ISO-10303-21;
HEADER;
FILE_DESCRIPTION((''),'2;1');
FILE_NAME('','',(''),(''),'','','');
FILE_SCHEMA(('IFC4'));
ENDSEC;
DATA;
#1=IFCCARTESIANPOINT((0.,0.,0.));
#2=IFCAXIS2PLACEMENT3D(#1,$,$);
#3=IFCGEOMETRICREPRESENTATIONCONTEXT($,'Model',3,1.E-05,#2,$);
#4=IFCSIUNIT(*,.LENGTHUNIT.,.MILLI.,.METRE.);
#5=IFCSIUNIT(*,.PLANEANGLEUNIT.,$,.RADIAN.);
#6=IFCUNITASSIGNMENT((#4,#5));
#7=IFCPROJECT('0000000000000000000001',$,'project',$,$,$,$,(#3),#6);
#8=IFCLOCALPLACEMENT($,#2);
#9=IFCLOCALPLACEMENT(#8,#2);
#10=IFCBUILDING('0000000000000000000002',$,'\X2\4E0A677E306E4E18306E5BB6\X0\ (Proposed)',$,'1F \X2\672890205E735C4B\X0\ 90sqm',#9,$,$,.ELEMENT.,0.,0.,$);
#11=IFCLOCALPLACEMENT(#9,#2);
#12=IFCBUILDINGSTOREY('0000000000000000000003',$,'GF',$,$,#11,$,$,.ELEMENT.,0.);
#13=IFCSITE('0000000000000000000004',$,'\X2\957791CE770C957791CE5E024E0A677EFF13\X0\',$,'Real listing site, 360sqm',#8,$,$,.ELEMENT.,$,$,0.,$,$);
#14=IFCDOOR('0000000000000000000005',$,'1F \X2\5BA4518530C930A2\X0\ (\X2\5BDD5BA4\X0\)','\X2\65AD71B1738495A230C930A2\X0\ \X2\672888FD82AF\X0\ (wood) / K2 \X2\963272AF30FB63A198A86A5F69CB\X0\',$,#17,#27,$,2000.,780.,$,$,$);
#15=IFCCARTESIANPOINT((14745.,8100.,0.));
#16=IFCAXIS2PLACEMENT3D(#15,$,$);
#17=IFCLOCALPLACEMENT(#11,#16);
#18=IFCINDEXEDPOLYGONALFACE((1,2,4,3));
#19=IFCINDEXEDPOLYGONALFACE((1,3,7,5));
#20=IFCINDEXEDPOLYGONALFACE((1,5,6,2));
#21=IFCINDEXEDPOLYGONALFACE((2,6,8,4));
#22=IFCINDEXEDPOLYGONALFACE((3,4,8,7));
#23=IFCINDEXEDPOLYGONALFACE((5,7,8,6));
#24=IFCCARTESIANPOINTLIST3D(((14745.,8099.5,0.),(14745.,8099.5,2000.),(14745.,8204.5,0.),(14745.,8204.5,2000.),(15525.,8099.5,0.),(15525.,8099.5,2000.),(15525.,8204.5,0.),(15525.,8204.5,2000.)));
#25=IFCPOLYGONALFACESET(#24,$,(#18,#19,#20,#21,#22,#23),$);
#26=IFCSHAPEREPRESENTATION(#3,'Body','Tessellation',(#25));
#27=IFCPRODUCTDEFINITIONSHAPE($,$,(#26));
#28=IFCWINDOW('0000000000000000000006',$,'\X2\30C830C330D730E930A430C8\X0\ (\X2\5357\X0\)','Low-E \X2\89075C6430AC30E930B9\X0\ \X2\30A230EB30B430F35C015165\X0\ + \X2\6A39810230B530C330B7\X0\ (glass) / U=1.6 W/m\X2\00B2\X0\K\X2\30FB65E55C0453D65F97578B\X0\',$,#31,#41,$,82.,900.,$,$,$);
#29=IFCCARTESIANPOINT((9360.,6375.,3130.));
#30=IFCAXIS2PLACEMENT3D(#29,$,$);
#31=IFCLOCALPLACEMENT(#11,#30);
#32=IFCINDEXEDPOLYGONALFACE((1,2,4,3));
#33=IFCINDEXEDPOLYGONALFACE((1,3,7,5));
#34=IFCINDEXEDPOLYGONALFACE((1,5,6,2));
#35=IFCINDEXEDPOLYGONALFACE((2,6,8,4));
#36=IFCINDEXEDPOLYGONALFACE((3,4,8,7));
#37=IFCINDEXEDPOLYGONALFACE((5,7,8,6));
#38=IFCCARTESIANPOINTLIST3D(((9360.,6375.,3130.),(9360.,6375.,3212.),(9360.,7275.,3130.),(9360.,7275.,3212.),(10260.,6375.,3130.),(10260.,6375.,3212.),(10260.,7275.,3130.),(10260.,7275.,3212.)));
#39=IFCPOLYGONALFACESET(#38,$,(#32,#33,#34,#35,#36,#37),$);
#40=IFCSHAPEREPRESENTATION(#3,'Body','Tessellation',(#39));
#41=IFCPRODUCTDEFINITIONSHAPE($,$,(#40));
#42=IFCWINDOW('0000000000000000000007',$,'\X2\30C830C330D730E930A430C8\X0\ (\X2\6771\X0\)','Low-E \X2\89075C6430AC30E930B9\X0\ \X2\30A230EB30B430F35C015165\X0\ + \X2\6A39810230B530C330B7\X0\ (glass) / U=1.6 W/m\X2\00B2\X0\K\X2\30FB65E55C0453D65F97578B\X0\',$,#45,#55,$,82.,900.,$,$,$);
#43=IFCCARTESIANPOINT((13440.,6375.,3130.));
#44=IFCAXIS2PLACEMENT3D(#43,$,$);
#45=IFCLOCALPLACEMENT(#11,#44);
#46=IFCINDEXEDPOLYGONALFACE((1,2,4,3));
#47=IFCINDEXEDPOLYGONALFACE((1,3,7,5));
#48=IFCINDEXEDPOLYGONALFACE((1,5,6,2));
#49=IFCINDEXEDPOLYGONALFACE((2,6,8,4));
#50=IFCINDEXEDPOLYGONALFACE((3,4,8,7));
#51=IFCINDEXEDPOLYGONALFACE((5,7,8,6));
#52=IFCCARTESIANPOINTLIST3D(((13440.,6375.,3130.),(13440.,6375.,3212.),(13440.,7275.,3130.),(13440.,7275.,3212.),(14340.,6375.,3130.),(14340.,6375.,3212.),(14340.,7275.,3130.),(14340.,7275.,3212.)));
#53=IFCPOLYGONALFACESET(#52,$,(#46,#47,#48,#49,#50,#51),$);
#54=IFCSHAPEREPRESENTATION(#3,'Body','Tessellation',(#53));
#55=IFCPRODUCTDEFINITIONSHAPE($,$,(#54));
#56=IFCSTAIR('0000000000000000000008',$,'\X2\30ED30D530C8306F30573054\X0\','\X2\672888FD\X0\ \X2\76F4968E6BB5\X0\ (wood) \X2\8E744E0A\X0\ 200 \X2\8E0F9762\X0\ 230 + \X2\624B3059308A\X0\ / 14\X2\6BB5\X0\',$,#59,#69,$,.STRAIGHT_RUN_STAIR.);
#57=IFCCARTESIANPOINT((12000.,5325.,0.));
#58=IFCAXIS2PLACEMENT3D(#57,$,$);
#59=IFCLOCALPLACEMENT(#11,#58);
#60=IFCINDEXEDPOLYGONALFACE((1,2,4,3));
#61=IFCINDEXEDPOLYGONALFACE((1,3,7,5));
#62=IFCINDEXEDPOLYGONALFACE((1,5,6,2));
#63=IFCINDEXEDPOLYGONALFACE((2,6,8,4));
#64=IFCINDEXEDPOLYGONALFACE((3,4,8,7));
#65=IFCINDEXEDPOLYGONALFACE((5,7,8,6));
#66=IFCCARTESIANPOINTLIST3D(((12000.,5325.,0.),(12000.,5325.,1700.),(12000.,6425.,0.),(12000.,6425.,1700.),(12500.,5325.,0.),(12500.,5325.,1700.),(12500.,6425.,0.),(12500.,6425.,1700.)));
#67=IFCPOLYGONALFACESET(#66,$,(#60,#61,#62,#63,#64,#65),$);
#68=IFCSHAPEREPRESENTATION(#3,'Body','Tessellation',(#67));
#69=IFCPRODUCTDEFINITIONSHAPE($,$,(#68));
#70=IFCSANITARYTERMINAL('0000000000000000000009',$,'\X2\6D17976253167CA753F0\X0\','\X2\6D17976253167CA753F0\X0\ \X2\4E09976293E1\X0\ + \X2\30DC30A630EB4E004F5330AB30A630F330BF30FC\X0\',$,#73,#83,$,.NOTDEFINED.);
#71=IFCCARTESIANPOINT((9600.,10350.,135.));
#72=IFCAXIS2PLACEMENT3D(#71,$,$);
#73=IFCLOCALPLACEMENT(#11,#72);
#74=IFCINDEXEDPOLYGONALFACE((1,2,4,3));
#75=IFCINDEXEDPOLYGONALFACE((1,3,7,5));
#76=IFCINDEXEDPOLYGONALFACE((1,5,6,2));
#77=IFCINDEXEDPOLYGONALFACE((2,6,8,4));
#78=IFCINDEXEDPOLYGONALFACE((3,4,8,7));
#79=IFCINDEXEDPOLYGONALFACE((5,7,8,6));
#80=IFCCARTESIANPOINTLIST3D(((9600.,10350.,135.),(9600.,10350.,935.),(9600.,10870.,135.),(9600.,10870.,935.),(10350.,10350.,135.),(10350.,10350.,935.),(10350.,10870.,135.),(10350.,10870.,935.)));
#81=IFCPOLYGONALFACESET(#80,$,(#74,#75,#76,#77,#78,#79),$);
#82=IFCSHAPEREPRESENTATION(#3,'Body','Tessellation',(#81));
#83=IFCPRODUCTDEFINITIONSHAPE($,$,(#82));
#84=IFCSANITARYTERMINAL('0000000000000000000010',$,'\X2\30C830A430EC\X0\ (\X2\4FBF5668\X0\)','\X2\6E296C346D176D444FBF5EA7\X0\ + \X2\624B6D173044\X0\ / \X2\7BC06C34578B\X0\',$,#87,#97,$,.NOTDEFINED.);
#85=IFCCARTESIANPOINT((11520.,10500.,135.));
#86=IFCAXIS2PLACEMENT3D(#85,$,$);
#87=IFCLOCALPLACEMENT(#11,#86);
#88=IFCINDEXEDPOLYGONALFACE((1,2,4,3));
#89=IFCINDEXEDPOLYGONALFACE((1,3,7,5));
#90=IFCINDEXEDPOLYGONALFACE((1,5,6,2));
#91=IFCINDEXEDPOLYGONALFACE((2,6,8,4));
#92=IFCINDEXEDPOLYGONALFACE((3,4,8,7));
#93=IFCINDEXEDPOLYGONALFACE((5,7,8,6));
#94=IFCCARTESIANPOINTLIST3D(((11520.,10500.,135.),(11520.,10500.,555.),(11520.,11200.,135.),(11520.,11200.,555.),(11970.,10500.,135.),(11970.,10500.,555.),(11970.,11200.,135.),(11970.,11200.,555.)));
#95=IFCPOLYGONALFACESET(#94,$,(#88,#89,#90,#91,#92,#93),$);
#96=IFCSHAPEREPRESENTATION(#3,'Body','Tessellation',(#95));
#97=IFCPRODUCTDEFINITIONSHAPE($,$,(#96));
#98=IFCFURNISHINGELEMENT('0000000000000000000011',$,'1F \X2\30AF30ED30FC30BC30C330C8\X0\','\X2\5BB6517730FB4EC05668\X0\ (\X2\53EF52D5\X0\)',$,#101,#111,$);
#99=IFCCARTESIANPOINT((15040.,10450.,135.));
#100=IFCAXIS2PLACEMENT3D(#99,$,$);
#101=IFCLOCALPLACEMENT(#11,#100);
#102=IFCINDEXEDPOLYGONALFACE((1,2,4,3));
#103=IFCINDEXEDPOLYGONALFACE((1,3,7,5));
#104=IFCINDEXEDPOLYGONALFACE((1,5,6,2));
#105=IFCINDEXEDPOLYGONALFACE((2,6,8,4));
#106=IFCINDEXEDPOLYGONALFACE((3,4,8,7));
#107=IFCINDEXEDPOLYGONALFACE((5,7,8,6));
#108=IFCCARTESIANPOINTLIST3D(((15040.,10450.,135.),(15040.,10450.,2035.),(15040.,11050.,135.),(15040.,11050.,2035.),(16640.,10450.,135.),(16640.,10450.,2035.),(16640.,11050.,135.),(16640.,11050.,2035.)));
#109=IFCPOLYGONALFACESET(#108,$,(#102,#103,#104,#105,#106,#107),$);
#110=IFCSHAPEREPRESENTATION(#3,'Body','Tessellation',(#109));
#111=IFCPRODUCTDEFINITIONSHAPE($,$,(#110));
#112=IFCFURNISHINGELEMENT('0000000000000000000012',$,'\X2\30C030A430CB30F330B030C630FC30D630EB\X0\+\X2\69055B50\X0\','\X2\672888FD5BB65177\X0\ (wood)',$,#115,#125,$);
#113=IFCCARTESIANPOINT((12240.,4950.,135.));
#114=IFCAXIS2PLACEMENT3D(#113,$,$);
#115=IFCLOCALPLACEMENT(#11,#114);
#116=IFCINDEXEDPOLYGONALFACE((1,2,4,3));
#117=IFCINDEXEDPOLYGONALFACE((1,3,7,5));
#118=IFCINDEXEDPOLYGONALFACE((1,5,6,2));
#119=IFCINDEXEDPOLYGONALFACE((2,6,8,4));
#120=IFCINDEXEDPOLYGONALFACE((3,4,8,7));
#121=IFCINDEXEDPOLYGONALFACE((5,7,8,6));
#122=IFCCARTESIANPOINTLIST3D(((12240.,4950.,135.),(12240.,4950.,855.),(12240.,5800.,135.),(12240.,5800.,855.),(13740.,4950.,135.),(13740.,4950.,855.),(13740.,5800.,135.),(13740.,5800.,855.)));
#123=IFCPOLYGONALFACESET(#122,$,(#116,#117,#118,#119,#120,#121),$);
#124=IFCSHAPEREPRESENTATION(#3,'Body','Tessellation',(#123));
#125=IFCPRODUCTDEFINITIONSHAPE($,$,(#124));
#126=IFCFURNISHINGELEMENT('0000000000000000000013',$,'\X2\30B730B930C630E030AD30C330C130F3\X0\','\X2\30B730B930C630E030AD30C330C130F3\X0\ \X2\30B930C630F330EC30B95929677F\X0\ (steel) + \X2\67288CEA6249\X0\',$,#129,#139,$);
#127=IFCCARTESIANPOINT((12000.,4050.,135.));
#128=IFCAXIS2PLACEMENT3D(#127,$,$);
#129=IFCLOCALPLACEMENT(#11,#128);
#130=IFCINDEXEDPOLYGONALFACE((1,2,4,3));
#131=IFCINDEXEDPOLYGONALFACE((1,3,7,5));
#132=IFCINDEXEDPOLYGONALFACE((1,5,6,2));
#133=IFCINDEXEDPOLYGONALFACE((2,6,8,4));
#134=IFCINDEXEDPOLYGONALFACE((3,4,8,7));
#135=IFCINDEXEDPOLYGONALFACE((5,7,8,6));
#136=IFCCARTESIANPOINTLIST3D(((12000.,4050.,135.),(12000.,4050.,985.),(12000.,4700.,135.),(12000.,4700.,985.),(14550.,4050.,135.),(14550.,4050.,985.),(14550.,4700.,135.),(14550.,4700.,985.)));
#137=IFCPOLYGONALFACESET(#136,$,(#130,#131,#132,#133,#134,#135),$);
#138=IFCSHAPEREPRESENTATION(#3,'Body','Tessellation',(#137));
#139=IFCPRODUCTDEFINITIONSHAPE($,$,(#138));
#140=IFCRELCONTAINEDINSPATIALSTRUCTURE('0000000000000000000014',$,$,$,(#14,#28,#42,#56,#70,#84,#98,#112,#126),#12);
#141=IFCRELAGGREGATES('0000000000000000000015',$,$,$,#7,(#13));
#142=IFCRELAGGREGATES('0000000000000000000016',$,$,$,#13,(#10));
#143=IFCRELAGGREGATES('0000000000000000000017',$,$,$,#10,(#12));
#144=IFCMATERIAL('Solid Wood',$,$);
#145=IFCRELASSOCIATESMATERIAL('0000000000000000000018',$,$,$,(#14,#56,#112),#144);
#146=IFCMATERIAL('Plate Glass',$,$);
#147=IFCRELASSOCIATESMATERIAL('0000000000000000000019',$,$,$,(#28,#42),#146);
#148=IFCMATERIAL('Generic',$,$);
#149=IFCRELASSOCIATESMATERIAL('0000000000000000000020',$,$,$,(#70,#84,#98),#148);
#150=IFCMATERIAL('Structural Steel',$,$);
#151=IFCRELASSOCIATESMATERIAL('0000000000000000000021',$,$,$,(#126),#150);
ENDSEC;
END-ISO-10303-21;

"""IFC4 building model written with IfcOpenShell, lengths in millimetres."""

from ifc_helpers import new_model, si_unit, frame, frame_2d, origin, place, context, project, spatial, rectangle, extrude, material, element, save


model = new_model("IFC4")

# Units and contexts
model_context = context("Model", 3, precision=1e-05, world=origin())
ifc_project = project(units=[si_unit("LENGTHUNIT", "METRE", prefix="MILLI"), si_unit("PLANEANGLEUNIT", "RADIAN")], contexts=[model_context])

# Site, building, storey
site_placement = place(None, origin())
site = spatial("IfcSite", under=ifc_project, at=site_placement, Name="長野県長野市上松３", ObjectType="Real listing site, 360sqm", CompositionType="ELEMENT", RefElevation=0.0)
building_placement = place(site_placement, origin())
building = spatial("IfcBuilding", under=site, at=building_placement, Name="上松の丘の家 (Proposed)", ObjectType="1F 木造平屋 90sqm", CompositionType="ELEMENT", ElevationOfRefHeight=0.0, ElevationOfTerrain=0.0)
storey_placement = place(building_placement, origin())
storey = spatial("IfcBuildingStorey", under=building, at=storey_placement, Name="GF", CompositionType="ELEMENT", Elevation=0.0)

# Shared definitions
ifc_material_1 = material(Name="Solid Wood")
ifc_material_2 = material(Name="Plate Glass")

# Door
door_placement = place(storey_placement, frame((14745.0, 8100.0, 0.0)))
element("IfcDoor", 1, at=door_placement, inside=storey, material=ifc_material_1, Name="1F 室内ドア (寝室)", Description="断熱玄関ドア 木製芯 (wood) / K2 防犯・採風機構", OverallHeight=2000.0, OverallWidth=780.0, context=model_context, shape_type="SweptSolid", body=[
    extrude(rectangle(XDim=780.0, YDim=105.0, at=frame_2d((390.0, 52.0))), frame((14745.0, 8100.0, 0.0)), (0.0, 0.0, 1.0), 2000.0),
])

# Windows
window_1_placement = place(storey_placement, frame((9360.0, 6375.0, 3130.0)))
element("IfcWindow", 2, at=window_1_placement, inside=storey, material=ifc_material_2, Name="トップライト (南)", Description="Low-E 複層ガラス アルゴン封入 + 樹脂サッシ (glass) / U=1.6 W/m²K・日射取得型", OverallHeight=82.0, OverallWidth=900.0, context=model_context, shape_type="SweptSolid", body=[
    extrude(rectangle(XDim=900.0, YDim=900.0, at=frame_2d((450.0, 450.0))), frame((9360.0, 6375.0, 3130.0)), (0.0, 0.0, 1.0), 82.0),
])
window_2_placement = place(storey_placement, frame((13440.0, 6375.0, 3130.0)))
element("IfcWindow", 3, at=window_2_placement, inside=storey, material=ifc_material_2, Name="トップライト (東)", Description="Low-E 複層ガラス アルゴン封入 + 樹脂サッシ (glass) / U=1.6 W/m²K・日射取得型", OverallHeight=82.0, OverallWidth=900.0, context=model_context, shape_type="SweptSolid", body=[
    extrude(rectangle(XDim=900.0, YDim=900.0, at=frame_2d((450.0, 450.0))), frame((13440.0, 6375.0, 3130.0)), (0.0, 0.0, 1.0), 82.0),
])

# Stair
stair_placement = place(storey_placement, frame((12000.0, 5325.0, 0.0)))
element("IfcStair", 4, at=stair_placement, inside=storey, material=ifc_material_1, Name="ロフトはしご", Description="木製 直階段 (wood) 蹴上 200 踏面 230 + 手すり / 14段", PredefinedType="STRAIGHT_RUN_STAIR", context=model_context, shape_type="SweptSolid", body=[
    extrude(rectangle(XDim=500.0, YDim=1100.0, at=frame_2d((250.0, 550.0))), frame((12000.0, 5325.0, 0.0)), (0.0, 0.0, 1.0), 1700.0),
])

# Sanitary terminals
ifc_material_3 = material(Name="Generic")
sanitary_terminal_1_placement = place(storey_placement, frame((9600.0, 10350.0, 135.0)))
element("IfcSanitaryTerminal", 5, at=sanitary_terminal_1_placement, inside=storey, material=ifc_material_3, Name="洗面化粧台", Description="洗面化粧台 三面鏡 + ボウル一体カウンター", PredefinedType="NOTDEFINED", context=model_context, shape_type="SweptSolid", body=[
    extrude(rectangle(XDim=750.0, YDim=520.0, at=frame_2d((375.0, 260.0))), frame((9600.0, 10350.0, 135.0)), (0.0, 0.0, 1.0), 800.0),
])
sanitary_terminal_2_placement = place(storey_placement, frame((11520.0, 10500.0, 135.0)))
element("IfcSanitaryTerminal", 6, at=sanitary_terminal_2_placement, inside=storey, material=ifc_material_3, Name="トイレ (便器)", Description="温水洗浄便座 + 手洗い / 節水型", PredefinedType="NOTDEFINED", context=model_context, shape_type="SweptSolid", body=[
    extrude(rectangle(XDim=450.0, YDim=700.0, at=frame_2d((225.0, 350.0))), frame((11520.0, 10500.0, 135.0)), (0.0, 0.0, 1.0), 420.0),
])

# Furnishing elements
furnishing_1_placement = place(storey_placement, frame((15040.0, 10450.0, 135.0)))
element("IfcFurnishingElement", 7, at=furnishing_1_placement, inside=storey, material=ifc_material_3, Name="1F クローゼット", Description="家具・什器 (可動)", context=model_context, shape_type="SweptSolid", body=[
    extrude(rectangle(XDim=1600.0, YDim=600.0, at=frame_2d((800.0, 300.0))), frame((15040.0, 10450.0, 135.0)), (0.0, 0.0, 1.0), 1900.0),
])
furnishing_2_placement = place(storey_placement, frame((12240.0, 4950.0, 135.0)))
element("IfcFurnishingElement", 8, at=furnishing_2_placement, inside=storey, material=ifc_material_1, Name="ダイニングテーブル+椅子", Description="木製家具 (wood)", context=model_context, shape_type="SweptSolid", body=[
    extrude(rectangle(XDim=1500.0, YDim=850.0, at=frame_2d((750.0, 425.0))), frame((12240.0, 4950.0, 135.0)), (0.0, 0.0, 1.0), 720.0),
])
ifc_material_4 = material(Name="Structural Steel")
furnishing_3_placement = place(storey_placement, frame((12000.0, 4050.0, 135.0)))
element("IfcFurnishingElement", 9, at=furnishing_3_placement, inside=storey, material=ifc_material_4, Name="システムキッチン", Description="システムキッチン ステンレス天板 (steel) + 木質扉", context=model_context, shape_type="SweptSolid", body=[
    extrude(rectangle(XDim=2550.0, YDim=650.0, at=frame_2d((1275.0, 325.0))), frame((12000.0, 4050.0, 135.0)), (0.0, 0.0, 1.0), 850.0),
])

save(model, "model.ifc")
